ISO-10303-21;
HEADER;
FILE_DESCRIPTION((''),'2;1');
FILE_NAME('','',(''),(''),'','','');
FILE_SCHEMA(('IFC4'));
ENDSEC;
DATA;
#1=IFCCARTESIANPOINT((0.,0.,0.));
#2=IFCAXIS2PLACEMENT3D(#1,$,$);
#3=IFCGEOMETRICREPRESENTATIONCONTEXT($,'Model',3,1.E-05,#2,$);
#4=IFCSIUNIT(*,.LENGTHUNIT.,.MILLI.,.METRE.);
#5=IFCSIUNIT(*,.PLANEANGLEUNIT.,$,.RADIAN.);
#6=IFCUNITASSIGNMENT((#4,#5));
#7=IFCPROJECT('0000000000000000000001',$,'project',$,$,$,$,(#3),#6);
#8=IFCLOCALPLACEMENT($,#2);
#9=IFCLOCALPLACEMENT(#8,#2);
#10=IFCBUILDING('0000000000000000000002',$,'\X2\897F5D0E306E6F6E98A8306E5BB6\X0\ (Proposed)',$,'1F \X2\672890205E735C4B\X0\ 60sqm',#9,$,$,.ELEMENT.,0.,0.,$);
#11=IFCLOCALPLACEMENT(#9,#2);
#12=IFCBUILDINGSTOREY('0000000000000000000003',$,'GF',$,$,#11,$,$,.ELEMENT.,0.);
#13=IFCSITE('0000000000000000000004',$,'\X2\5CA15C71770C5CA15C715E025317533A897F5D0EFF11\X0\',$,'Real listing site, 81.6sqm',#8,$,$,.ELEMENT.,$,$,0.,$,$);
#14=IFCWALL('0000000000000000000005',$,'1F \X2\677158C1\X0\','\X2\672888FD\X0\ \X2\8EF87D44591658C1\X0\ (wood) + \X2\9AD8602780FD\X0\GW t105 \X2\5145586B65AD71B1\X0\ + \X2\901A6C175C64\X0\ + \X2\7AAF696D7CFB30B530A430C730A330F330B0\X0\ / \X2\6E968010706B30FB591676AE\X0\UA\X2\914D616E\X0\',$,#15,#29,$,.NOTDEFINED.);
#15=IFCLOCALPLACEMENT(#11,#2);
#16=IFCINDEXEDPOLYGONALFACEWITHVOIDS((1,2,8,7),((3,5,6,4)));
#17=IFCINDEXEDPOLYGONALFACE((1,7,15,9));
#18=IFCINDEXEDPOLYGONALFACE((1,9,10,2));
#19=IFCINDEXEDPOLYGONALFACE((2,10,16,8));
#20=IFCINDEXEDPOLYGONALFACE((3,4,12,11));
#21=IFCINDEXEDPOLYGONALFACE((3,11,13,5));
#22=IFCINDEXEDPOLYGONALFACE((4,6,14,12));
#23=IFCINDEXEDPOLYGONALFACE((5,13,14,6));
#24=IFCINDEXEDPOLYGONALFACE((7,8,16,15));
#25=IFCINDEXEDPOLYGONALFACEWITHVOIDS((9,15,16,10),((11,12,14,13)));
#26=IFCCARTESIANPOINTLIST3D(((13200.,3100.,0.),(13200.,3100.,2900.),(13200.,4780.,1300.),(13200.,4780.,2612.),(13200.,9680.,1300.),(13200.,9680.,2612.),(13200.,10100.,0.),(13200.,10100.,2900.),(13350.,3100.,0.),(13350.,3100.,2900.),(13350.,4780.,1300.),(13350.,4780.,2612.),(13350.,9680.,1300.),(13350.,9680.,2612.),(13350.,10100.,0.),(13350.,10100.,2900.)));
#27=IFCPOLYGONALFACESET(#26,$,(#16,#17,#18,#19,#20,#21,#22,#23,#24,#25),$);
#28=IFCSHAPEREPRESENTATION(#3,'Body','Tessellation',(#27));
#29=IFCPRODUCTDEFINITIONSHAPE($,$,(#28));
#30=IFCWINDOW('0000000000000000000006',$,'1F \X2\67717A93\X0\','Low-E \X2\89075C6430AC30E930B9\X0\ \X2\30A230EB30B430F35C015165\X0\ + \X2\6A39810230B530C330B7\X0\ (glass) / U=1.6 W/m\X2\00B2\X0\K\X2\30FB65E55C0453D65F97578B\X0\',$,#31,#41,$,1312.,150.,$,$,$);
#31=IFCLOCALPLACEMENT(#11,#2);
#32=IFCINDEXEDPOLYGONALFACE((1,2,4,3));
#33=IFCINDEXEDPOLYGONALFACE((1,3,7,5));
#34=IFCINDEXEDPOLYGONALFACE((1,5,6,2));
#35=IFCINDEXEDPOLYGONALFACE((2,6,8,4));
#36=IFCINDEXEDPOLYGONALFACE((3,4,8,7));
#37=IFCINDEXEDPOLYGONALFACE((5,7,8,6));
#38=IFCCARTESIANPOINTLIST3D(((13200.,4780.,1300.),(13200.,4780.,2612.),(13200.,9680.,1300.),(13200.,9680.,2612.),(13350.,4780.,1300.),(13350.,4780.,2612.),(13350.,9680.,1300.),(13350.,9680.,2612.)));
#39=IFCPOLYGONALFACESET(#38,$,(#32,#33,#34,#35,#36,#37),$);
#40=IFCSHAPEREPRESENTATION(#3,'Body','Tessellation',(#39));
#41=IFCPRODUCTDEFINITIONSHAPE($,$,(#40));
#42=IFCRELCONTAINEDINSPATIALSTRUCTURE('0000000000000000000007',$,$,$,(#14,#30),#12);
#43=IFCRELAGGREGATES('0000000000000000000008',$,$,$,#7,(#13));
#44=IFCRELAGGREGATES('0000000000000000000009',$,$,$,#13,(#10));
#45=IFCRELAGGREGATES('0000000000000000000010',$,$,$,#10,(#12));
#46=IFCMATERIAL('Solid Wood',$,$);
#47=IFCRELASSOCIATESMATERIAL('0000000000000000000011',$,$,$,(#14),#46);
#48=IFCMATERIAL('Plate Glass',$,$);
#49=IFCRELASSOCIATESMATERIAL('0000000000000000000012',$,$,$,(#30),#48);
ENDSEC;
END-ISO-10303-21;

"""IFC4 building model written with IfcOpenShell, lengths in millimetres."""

from ifc_helpers import new_model, si_unit, frame, frame_2d, origin, place, context, project, spatial, rectangle, extrude, material, element, fill, save


model = new_model("IFC4")

# Units and contexts
model_context = context("Model", 3, precision=1e-05, world=origin())
ifc_project = project(units=[si_unit("LENGTHUNIT", "METRE", prefix="MILLI"), si_unit("PLANEANGLEUNIT", "RADIAN")], contexts=[model_context])

# Site, building, storey
site_placement = place(None, origin())
site = spatial("IfcSite", under=ifc_project, at=site_placement, Name="岡山県岡山市北区西崎１", ObjectType="Real listing site, 81.6sqm", CompositionType="ELEMENT", RefElevation=0.0)
building_placement = place(site_placement, origin())
building = spatial("IfcBuilding", under=site, at=building_placement, Name="西崎の潮風の家 (Proposed)", ObjectType="1F 木造平屋 60sqm", CompositionType="ELEMENT", ElevationOfRefHeight=0.0, ElevationOfTerrain=0.0)
storey_placement = place(building_placement, origin())
storey = spatial("IfcBuildingStorey", under=building, at=storey_placement, Name="GF", CompositionType="ELEMENT", Elevation=0.0)

# Shared definitions
ifc_material_1 = material(Name="Solid Wood")

# Shared definitions
ifc_material_2 = material(Name="Plate Glass")

# Wall, opening, window
wall_1_placement = place(storey_placement, frame((6600.0, 1550.0, 0.0)))
wall_1 = element("IfcWall", 1, at=wall_1_placement, inside=storey, material=ifc_material_1, Name="1F 東壁", Description="木製 軸組外壁 (wood) + 高性能GW t105 充填断熱 + 通気層 + 窯業系サイディング / 準耐火・外皮UA配慮", PredefinedType="NOTDEFINED", context=model_context, shape_type="SweptSolid", body=[
    extrude(rectangle(XDim=150.0, YDim=7000.0, at=frame_2d((75.0, 3500.0))), frame((6600.0, 1550.0, 0.0)), (0.0, 0.0, 1.0), 2900.0),
])
opening_1_placement = place(storey_placement, frame((6600.0, 2390.0, 650.0)))
opening_1 = element("IfcOpeningElement", 2, at=opening_1_placement, cuts=wall_1, PredefinedType="NOTDEFINED", context=model_context, shape_type="SweptSolid", body=[
    extrude(rectangle(XDim=150.0, YDim=4900.0, at=frame_2d((75.0, 2450.0))), frame((6600.0, 2390.0, 650.0)), (0.0, 0.0, 1.0), 1312.0),
])
window_1_placement = place(storey_placement, frame((6600.0, 2390.0, 650.0)))
window_1 = element("IfcWindow", 3, at=window_1_placement, inside=storey, material=ifc_material_2, Name="1F 東窓", Description="Low-E 複層ガラス アルゴン封入 + 樹脂サッシ (glass) / U=1.6 W/m²K・日射取得型", OverallHeight=1312.0, OverallWidth=150.0, context=model_context, shape_type="SweptSolid", body=[
    extrude(rectangle(XDim=150.0, YDim=4900.0, at=frame_2d((75.0, 2450.0))), frame((6600.0, 2390.0, 650.0)), (0.0, 0.0, 1.0), 1312.0),
])
fill(opening_1, window_1)

save(model, "model.ifc")
